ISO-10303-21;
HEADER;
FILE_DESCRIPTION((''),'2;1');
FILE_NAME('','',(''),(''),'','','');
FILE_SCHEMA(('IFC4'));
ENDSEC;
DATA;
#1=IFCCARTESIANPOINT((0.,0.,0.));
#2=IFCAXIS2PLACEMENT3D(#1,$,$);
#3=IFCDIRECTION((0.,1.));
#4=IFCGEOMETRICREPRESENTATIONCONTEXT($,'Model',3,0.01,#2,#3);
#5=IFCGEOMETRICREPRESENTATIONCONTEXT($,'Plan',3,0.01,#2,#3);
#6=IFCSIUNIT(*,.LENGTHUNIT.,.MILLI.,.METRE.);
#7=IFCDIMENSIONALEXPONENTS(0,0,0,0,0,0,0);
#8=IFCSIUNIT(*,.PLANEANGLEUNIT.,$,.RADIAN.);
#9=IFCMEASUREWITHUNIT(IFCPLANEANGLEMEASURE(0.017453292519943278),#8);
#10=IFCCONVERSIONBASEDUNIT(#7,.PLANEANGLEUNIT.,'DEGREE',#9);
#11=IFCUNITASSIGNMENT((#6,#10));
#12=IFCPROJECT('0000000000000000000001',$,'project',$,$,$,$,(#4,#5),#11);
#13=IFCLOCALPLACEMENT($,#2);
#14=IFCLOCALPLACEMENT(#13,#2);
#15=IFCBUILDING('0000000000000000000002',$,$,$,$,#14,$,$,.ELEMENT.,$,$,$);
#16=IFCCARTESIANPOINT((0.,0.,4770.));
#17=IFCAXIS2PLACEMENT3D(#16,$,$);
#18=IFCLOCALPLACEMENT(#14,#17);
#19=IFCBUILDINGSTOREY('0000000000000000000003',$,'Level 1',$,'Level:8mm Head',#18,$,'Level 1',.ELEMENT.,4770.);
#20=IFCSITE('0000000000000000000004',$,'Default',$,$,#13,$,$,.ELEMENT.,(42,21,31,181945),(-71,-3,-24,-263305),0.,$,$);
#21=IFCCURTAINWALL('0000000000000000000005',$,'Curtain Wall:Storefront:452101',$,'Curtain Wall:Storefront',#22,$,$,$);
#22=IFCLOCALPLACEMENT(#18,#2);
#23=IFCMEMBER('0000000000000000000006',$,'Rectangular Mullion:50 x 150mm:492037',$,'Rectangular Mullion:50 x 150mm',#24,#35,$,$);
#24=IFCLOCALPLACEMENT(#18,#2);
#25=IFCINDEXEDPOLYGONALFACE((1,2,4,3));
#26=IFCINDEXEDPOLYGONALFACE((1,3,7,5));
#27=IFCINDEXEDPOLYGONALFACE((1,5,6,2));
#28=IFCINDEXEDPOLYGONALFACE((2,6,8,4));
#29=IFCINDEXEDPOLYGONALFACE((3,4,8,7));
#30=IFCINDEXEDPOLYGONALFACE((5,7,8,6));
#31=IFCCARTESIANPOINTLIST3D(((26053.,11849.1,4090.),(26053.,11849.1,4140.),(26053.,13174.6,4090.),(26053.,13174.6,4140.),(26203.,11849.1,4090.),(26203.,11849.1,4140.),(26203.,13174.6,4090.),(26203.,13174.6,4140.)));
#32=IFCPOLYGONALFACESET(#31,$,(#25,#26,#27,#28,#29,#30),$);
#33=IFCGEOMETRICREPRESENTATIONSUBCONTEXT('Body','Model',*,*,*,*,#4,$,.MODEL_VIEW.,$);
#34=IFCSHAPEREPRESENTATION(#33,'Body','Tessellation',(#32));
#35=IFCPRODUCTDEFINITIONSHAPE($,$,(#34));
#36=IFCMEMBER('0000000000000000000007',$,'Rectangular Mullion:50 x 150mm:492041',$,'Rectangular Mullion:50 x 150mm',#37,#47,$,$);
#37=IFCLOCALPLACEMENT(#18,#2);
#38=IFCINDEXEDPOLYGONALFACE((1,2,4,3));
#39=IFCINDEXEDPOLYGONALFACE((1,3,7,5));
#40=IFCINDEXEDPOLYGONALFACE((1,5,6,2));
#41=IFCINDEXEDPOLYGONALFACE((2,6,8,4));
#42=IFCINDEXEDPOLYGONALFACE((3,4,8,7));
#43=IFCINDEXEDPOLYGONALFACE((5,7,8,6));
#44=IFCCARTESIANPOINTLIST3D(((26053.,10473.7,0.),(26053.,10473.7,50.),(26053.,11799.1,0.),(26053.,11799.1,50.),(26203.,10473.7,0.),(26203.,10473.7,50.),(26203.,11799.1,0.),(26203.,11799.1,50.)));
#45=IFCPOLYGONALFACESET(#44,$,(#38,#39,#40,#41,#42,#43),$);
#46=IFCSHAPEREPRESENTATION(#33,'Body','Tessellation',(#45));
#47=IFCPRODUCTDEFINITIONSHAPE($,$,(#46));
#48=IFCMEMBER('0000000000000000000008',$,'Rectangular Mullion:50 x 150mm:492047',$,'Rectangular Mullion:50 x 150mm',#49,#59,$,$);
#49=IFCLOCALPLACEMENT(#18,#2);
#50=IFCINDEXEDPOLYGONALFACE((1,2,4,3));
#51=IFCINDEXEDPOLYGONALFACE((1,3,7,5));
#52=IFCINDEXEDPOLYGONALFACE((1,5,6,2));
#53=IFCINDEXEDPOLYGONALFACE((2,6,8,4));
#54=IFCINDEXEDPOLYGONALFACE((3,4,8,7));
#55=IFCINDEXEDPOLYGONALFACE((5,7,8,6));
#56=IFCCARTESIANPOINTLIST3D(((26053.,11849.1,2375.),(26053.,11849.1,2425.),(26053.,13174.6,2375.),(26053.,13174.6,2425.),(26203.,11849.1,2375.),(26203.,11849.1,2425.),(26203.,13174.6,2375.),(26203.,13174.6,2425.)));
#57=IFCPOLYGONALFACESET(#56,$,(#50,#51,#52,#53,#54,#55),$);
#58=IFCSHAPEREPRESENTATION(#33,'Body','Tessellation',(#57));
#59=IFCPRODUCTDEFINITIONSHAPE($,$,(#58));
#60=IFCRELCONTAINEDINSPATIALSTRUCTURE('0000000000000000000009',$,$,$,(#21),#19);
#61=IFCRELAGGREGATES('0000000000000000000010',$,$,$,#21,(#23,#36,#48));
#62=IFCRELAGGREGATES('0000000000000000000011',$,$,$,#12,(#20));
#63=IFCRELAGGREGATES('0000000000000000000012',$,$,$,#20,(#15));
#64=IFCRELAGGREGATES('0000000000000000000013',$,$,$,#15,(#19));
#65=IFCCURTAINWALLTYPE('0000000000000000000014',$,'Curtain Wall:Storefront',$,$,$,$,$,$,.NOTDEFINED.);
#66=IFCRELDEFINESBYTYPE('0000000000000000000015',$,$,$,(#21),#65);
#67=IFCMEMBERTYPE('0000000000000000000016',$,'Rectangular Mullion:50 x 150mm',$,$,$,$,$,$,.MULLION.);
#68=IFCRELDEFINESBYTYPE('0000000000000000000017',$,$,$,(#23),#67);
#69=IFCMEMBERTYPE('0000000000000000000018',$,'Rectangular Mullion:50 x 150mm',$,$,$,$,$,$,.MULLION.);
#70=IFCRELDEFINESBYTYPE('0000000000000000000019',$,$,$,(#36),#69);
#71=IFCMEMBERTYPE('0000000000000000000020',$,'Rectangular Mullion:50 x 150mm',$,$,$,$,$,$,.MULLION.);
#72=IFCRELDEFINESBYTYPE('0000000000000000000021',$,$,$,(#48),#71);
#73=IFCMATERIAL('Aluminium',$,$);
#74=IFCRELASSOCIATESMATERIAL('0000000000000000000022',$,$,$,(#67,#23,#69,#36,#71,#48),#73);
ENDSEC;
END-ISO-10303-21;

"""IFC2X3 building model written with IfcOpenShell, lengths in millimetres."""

from ifc_helpers import new_model, entity, si_unit, converted_unit, direction, frame, origin, origin_2d_with_axis, place, context, subcontext, project, spatial, rectangle, extrude, source, transform, mapped, material, type_object, type_shapes, element, aggregate, save


model = new_model("IFC2X3")

# Units and contexts
model_context = context("Model", 3, precision=0.01, world=origin(), true_north=direction((0.0, 1.0)))
plan_context = context("Plan", 3, precision=0.01, world=origin(), true_north=direction((0.0, 1.0)))
body_context = subcontext(model_context, "Body", "Model", "MODEL_VIEW")
ifc_project = project(units=[si_unit("LENGTHUNIT", "METRE", prefix="MILLI"), converted_unit("PLANEANGLEUNIT", "DEGREE", entity("IfcPlaneAngleMeasure", 0.017453292519943278), si_unit("PLANEANGLEUNIT", "RADIAN"), dimensions=[0, 0, 0, 0, 0, 0, 0])], contexts=[model_context, plan_context])

# Site, building, storey
site_placement = place(None, origin())
site = spatial("IfcSite", under=ifc_project, at=site_placement, Name="Default", CompositionType="ELEMENT", RefLatitude=(42, 21, 31, 181945), RefLongitude=(-71, -3, -24, -263305), RefElevation=0.0)
building_placement = place(site_placement, origin())
building = spatial("IfcBuilding", under=site, at=building_placement, CompositionType="ELEMENT")
storey_placement = place(building_placement, frame((0.0, 0.0, 4770.0)))
storey = spatial("IfcBuildingStorey", under=building, at=storey_placement, Name="Level 1", ObjectType="Level:8mm Head", LongName="Level 1", CompositionType="ELEMENT", Elevation=4770.0)

# Curtain wall
curtain_wall_type = type_object("IfcCurtainWallType", Name="Curtain Wall:Storefront", PredefinedType="NOTDEFINED")
ifc_material_1 = material(Name="Aluminium")
curtain_wall_1_placement = place(storey_placement, frame((0.0, 0.0, -4770.0)))
curtain_wall_1 = element("IfcCurtainWall", 1, at=curtain_wall_1_placement, inside=storey, type_object=curtain_wall_type, Name="Curtain Wall:Storefront:452101", ObjectType="Curtain Wall:Storefront")

# Members
member_type_1 = type_object("IfcMemberType", Name="Rectangular Mullion:50 x 150mm", PredefinedType="MULLION", material=ifc_material_1)
shared_shape_1 = source(origin(), body_context, "Body", "SweptSolid", [
    extrude(rectangle(XDim=50.0, YDim=150.0, at=origin_2d_with_axis()), frame((-25.0, 0.0, -1325.4), z_axis=(0.0, 0.0, 1.0), x_axis=(-1.0, 0.0, 0.0)), (0.0, 0.0, 1.0), 1325.4),
])
type_shapes(member_type_1, [shared_shape_1])
member_1_placement = place(curtain_wall_1_placement, frame((26128.0, 11849.1, 8910.0), z_axis=(0.0, -1.0, 0.0), x_axis=(0.0, 0.0, 1.0)))
member_1 = element("IfcMember", 2, at=member_1_placement, type_object=member_type_1, material=ifc_material_1, Name="Rectangular Mullion:50 x 150mm:492037", ObjectType="Rectangular Mullion:50 x 150mm", context=body_context, shape_type="MappedRepresentation", body=[
    mapped(shared_shape_1, transform((0.0, 0.0, 0.0), scale=1.0)),
])
member_type_2 = type_object("IfcMemberType", Name="Rectangular Mullion:50 x 150mm", PredefinedType="MULLION", material=ifc_material_1)
shared_shape_2 = source(origin(), body_context, "Body", "SweptSolid", [
    extrude(rectangle(XDim=50.0, YDim=150.0, at=origin_2d_with_axis()), frame((-25.0, 0.0, -1325.4), z_axis=(0.0, 0.0, 1.0), x_axis=(-1.0, 0.0, 0.0)), (0.0, 0.0, 1.0), 1325.4),
])
type_shapes(member_type_2, [shared_shape_2])
member_2_placement = place(curtain_wall_1_placement, frame((26128.0, 11799.1, 4770.0), z_axis=(0.0, 1.0, 0.0), x_axis=(0.0, 0.0, -1.0)))
member_2 = element("IfcMember", 3, at=member_2_placement, type_object=member_type_2, material=ifc_material_1, Name="Rectangular Mullion:50 x 150mm:492041", ObjectType="Rectangular Mullion:50 x 150mm", context=body_context, shape_type="MappedRepresentation", body=[
    mapped(shared_shape_2, transform((0.0, 0.0, 0.0), scale=1.0)),
])
member_type_3 = type_object("IfcMemberType", Name="Rectangular Mullion:50 x 150mm", PredefinedType="MULLION", material=ifc_material_1)
shared_shape_3 = source(origin(), body_context, "Body", "SweptSolid", [
    extrude(rectangle(XDim=50.0, YDim=150.0, at=origin_2d_with_axis()), frame((0.0, 0.0, -1325.4), z_axis=(0.0, 0.0, 1.0), x_axis=(-1.0, 0.0, 0.0)), (0.0, 0.0, 1.0), 1325.4),
])
type_shapes(member_type_3, [shared_shape_3])
member_3_placement = place(curtain_wall_1_placement, frame((26128.0, 11849.1, 7170.0), z_axis=(0.0, -1.0, 0.0), x_axis=(0.0, 0.0, 1.0)))
member_3 = element("IfcMember", 4, at=member_3_placement, type_object=member_type_3, material=ifc_material_1, Name="Rectangular Mullion:50 x 150mm:492047", ObjectType="Rectangular Mullion:50 x 150mm", context=body_context, shape_type="MappedRepresentation", body=[
    mapped(shared_shape_3, transform((0.0, 0.0, 0.0), scale=1.0)),
])

aggregate(curtain_wall_1, [member_1, member_2, member_3])

save(model, "model.ifc")
